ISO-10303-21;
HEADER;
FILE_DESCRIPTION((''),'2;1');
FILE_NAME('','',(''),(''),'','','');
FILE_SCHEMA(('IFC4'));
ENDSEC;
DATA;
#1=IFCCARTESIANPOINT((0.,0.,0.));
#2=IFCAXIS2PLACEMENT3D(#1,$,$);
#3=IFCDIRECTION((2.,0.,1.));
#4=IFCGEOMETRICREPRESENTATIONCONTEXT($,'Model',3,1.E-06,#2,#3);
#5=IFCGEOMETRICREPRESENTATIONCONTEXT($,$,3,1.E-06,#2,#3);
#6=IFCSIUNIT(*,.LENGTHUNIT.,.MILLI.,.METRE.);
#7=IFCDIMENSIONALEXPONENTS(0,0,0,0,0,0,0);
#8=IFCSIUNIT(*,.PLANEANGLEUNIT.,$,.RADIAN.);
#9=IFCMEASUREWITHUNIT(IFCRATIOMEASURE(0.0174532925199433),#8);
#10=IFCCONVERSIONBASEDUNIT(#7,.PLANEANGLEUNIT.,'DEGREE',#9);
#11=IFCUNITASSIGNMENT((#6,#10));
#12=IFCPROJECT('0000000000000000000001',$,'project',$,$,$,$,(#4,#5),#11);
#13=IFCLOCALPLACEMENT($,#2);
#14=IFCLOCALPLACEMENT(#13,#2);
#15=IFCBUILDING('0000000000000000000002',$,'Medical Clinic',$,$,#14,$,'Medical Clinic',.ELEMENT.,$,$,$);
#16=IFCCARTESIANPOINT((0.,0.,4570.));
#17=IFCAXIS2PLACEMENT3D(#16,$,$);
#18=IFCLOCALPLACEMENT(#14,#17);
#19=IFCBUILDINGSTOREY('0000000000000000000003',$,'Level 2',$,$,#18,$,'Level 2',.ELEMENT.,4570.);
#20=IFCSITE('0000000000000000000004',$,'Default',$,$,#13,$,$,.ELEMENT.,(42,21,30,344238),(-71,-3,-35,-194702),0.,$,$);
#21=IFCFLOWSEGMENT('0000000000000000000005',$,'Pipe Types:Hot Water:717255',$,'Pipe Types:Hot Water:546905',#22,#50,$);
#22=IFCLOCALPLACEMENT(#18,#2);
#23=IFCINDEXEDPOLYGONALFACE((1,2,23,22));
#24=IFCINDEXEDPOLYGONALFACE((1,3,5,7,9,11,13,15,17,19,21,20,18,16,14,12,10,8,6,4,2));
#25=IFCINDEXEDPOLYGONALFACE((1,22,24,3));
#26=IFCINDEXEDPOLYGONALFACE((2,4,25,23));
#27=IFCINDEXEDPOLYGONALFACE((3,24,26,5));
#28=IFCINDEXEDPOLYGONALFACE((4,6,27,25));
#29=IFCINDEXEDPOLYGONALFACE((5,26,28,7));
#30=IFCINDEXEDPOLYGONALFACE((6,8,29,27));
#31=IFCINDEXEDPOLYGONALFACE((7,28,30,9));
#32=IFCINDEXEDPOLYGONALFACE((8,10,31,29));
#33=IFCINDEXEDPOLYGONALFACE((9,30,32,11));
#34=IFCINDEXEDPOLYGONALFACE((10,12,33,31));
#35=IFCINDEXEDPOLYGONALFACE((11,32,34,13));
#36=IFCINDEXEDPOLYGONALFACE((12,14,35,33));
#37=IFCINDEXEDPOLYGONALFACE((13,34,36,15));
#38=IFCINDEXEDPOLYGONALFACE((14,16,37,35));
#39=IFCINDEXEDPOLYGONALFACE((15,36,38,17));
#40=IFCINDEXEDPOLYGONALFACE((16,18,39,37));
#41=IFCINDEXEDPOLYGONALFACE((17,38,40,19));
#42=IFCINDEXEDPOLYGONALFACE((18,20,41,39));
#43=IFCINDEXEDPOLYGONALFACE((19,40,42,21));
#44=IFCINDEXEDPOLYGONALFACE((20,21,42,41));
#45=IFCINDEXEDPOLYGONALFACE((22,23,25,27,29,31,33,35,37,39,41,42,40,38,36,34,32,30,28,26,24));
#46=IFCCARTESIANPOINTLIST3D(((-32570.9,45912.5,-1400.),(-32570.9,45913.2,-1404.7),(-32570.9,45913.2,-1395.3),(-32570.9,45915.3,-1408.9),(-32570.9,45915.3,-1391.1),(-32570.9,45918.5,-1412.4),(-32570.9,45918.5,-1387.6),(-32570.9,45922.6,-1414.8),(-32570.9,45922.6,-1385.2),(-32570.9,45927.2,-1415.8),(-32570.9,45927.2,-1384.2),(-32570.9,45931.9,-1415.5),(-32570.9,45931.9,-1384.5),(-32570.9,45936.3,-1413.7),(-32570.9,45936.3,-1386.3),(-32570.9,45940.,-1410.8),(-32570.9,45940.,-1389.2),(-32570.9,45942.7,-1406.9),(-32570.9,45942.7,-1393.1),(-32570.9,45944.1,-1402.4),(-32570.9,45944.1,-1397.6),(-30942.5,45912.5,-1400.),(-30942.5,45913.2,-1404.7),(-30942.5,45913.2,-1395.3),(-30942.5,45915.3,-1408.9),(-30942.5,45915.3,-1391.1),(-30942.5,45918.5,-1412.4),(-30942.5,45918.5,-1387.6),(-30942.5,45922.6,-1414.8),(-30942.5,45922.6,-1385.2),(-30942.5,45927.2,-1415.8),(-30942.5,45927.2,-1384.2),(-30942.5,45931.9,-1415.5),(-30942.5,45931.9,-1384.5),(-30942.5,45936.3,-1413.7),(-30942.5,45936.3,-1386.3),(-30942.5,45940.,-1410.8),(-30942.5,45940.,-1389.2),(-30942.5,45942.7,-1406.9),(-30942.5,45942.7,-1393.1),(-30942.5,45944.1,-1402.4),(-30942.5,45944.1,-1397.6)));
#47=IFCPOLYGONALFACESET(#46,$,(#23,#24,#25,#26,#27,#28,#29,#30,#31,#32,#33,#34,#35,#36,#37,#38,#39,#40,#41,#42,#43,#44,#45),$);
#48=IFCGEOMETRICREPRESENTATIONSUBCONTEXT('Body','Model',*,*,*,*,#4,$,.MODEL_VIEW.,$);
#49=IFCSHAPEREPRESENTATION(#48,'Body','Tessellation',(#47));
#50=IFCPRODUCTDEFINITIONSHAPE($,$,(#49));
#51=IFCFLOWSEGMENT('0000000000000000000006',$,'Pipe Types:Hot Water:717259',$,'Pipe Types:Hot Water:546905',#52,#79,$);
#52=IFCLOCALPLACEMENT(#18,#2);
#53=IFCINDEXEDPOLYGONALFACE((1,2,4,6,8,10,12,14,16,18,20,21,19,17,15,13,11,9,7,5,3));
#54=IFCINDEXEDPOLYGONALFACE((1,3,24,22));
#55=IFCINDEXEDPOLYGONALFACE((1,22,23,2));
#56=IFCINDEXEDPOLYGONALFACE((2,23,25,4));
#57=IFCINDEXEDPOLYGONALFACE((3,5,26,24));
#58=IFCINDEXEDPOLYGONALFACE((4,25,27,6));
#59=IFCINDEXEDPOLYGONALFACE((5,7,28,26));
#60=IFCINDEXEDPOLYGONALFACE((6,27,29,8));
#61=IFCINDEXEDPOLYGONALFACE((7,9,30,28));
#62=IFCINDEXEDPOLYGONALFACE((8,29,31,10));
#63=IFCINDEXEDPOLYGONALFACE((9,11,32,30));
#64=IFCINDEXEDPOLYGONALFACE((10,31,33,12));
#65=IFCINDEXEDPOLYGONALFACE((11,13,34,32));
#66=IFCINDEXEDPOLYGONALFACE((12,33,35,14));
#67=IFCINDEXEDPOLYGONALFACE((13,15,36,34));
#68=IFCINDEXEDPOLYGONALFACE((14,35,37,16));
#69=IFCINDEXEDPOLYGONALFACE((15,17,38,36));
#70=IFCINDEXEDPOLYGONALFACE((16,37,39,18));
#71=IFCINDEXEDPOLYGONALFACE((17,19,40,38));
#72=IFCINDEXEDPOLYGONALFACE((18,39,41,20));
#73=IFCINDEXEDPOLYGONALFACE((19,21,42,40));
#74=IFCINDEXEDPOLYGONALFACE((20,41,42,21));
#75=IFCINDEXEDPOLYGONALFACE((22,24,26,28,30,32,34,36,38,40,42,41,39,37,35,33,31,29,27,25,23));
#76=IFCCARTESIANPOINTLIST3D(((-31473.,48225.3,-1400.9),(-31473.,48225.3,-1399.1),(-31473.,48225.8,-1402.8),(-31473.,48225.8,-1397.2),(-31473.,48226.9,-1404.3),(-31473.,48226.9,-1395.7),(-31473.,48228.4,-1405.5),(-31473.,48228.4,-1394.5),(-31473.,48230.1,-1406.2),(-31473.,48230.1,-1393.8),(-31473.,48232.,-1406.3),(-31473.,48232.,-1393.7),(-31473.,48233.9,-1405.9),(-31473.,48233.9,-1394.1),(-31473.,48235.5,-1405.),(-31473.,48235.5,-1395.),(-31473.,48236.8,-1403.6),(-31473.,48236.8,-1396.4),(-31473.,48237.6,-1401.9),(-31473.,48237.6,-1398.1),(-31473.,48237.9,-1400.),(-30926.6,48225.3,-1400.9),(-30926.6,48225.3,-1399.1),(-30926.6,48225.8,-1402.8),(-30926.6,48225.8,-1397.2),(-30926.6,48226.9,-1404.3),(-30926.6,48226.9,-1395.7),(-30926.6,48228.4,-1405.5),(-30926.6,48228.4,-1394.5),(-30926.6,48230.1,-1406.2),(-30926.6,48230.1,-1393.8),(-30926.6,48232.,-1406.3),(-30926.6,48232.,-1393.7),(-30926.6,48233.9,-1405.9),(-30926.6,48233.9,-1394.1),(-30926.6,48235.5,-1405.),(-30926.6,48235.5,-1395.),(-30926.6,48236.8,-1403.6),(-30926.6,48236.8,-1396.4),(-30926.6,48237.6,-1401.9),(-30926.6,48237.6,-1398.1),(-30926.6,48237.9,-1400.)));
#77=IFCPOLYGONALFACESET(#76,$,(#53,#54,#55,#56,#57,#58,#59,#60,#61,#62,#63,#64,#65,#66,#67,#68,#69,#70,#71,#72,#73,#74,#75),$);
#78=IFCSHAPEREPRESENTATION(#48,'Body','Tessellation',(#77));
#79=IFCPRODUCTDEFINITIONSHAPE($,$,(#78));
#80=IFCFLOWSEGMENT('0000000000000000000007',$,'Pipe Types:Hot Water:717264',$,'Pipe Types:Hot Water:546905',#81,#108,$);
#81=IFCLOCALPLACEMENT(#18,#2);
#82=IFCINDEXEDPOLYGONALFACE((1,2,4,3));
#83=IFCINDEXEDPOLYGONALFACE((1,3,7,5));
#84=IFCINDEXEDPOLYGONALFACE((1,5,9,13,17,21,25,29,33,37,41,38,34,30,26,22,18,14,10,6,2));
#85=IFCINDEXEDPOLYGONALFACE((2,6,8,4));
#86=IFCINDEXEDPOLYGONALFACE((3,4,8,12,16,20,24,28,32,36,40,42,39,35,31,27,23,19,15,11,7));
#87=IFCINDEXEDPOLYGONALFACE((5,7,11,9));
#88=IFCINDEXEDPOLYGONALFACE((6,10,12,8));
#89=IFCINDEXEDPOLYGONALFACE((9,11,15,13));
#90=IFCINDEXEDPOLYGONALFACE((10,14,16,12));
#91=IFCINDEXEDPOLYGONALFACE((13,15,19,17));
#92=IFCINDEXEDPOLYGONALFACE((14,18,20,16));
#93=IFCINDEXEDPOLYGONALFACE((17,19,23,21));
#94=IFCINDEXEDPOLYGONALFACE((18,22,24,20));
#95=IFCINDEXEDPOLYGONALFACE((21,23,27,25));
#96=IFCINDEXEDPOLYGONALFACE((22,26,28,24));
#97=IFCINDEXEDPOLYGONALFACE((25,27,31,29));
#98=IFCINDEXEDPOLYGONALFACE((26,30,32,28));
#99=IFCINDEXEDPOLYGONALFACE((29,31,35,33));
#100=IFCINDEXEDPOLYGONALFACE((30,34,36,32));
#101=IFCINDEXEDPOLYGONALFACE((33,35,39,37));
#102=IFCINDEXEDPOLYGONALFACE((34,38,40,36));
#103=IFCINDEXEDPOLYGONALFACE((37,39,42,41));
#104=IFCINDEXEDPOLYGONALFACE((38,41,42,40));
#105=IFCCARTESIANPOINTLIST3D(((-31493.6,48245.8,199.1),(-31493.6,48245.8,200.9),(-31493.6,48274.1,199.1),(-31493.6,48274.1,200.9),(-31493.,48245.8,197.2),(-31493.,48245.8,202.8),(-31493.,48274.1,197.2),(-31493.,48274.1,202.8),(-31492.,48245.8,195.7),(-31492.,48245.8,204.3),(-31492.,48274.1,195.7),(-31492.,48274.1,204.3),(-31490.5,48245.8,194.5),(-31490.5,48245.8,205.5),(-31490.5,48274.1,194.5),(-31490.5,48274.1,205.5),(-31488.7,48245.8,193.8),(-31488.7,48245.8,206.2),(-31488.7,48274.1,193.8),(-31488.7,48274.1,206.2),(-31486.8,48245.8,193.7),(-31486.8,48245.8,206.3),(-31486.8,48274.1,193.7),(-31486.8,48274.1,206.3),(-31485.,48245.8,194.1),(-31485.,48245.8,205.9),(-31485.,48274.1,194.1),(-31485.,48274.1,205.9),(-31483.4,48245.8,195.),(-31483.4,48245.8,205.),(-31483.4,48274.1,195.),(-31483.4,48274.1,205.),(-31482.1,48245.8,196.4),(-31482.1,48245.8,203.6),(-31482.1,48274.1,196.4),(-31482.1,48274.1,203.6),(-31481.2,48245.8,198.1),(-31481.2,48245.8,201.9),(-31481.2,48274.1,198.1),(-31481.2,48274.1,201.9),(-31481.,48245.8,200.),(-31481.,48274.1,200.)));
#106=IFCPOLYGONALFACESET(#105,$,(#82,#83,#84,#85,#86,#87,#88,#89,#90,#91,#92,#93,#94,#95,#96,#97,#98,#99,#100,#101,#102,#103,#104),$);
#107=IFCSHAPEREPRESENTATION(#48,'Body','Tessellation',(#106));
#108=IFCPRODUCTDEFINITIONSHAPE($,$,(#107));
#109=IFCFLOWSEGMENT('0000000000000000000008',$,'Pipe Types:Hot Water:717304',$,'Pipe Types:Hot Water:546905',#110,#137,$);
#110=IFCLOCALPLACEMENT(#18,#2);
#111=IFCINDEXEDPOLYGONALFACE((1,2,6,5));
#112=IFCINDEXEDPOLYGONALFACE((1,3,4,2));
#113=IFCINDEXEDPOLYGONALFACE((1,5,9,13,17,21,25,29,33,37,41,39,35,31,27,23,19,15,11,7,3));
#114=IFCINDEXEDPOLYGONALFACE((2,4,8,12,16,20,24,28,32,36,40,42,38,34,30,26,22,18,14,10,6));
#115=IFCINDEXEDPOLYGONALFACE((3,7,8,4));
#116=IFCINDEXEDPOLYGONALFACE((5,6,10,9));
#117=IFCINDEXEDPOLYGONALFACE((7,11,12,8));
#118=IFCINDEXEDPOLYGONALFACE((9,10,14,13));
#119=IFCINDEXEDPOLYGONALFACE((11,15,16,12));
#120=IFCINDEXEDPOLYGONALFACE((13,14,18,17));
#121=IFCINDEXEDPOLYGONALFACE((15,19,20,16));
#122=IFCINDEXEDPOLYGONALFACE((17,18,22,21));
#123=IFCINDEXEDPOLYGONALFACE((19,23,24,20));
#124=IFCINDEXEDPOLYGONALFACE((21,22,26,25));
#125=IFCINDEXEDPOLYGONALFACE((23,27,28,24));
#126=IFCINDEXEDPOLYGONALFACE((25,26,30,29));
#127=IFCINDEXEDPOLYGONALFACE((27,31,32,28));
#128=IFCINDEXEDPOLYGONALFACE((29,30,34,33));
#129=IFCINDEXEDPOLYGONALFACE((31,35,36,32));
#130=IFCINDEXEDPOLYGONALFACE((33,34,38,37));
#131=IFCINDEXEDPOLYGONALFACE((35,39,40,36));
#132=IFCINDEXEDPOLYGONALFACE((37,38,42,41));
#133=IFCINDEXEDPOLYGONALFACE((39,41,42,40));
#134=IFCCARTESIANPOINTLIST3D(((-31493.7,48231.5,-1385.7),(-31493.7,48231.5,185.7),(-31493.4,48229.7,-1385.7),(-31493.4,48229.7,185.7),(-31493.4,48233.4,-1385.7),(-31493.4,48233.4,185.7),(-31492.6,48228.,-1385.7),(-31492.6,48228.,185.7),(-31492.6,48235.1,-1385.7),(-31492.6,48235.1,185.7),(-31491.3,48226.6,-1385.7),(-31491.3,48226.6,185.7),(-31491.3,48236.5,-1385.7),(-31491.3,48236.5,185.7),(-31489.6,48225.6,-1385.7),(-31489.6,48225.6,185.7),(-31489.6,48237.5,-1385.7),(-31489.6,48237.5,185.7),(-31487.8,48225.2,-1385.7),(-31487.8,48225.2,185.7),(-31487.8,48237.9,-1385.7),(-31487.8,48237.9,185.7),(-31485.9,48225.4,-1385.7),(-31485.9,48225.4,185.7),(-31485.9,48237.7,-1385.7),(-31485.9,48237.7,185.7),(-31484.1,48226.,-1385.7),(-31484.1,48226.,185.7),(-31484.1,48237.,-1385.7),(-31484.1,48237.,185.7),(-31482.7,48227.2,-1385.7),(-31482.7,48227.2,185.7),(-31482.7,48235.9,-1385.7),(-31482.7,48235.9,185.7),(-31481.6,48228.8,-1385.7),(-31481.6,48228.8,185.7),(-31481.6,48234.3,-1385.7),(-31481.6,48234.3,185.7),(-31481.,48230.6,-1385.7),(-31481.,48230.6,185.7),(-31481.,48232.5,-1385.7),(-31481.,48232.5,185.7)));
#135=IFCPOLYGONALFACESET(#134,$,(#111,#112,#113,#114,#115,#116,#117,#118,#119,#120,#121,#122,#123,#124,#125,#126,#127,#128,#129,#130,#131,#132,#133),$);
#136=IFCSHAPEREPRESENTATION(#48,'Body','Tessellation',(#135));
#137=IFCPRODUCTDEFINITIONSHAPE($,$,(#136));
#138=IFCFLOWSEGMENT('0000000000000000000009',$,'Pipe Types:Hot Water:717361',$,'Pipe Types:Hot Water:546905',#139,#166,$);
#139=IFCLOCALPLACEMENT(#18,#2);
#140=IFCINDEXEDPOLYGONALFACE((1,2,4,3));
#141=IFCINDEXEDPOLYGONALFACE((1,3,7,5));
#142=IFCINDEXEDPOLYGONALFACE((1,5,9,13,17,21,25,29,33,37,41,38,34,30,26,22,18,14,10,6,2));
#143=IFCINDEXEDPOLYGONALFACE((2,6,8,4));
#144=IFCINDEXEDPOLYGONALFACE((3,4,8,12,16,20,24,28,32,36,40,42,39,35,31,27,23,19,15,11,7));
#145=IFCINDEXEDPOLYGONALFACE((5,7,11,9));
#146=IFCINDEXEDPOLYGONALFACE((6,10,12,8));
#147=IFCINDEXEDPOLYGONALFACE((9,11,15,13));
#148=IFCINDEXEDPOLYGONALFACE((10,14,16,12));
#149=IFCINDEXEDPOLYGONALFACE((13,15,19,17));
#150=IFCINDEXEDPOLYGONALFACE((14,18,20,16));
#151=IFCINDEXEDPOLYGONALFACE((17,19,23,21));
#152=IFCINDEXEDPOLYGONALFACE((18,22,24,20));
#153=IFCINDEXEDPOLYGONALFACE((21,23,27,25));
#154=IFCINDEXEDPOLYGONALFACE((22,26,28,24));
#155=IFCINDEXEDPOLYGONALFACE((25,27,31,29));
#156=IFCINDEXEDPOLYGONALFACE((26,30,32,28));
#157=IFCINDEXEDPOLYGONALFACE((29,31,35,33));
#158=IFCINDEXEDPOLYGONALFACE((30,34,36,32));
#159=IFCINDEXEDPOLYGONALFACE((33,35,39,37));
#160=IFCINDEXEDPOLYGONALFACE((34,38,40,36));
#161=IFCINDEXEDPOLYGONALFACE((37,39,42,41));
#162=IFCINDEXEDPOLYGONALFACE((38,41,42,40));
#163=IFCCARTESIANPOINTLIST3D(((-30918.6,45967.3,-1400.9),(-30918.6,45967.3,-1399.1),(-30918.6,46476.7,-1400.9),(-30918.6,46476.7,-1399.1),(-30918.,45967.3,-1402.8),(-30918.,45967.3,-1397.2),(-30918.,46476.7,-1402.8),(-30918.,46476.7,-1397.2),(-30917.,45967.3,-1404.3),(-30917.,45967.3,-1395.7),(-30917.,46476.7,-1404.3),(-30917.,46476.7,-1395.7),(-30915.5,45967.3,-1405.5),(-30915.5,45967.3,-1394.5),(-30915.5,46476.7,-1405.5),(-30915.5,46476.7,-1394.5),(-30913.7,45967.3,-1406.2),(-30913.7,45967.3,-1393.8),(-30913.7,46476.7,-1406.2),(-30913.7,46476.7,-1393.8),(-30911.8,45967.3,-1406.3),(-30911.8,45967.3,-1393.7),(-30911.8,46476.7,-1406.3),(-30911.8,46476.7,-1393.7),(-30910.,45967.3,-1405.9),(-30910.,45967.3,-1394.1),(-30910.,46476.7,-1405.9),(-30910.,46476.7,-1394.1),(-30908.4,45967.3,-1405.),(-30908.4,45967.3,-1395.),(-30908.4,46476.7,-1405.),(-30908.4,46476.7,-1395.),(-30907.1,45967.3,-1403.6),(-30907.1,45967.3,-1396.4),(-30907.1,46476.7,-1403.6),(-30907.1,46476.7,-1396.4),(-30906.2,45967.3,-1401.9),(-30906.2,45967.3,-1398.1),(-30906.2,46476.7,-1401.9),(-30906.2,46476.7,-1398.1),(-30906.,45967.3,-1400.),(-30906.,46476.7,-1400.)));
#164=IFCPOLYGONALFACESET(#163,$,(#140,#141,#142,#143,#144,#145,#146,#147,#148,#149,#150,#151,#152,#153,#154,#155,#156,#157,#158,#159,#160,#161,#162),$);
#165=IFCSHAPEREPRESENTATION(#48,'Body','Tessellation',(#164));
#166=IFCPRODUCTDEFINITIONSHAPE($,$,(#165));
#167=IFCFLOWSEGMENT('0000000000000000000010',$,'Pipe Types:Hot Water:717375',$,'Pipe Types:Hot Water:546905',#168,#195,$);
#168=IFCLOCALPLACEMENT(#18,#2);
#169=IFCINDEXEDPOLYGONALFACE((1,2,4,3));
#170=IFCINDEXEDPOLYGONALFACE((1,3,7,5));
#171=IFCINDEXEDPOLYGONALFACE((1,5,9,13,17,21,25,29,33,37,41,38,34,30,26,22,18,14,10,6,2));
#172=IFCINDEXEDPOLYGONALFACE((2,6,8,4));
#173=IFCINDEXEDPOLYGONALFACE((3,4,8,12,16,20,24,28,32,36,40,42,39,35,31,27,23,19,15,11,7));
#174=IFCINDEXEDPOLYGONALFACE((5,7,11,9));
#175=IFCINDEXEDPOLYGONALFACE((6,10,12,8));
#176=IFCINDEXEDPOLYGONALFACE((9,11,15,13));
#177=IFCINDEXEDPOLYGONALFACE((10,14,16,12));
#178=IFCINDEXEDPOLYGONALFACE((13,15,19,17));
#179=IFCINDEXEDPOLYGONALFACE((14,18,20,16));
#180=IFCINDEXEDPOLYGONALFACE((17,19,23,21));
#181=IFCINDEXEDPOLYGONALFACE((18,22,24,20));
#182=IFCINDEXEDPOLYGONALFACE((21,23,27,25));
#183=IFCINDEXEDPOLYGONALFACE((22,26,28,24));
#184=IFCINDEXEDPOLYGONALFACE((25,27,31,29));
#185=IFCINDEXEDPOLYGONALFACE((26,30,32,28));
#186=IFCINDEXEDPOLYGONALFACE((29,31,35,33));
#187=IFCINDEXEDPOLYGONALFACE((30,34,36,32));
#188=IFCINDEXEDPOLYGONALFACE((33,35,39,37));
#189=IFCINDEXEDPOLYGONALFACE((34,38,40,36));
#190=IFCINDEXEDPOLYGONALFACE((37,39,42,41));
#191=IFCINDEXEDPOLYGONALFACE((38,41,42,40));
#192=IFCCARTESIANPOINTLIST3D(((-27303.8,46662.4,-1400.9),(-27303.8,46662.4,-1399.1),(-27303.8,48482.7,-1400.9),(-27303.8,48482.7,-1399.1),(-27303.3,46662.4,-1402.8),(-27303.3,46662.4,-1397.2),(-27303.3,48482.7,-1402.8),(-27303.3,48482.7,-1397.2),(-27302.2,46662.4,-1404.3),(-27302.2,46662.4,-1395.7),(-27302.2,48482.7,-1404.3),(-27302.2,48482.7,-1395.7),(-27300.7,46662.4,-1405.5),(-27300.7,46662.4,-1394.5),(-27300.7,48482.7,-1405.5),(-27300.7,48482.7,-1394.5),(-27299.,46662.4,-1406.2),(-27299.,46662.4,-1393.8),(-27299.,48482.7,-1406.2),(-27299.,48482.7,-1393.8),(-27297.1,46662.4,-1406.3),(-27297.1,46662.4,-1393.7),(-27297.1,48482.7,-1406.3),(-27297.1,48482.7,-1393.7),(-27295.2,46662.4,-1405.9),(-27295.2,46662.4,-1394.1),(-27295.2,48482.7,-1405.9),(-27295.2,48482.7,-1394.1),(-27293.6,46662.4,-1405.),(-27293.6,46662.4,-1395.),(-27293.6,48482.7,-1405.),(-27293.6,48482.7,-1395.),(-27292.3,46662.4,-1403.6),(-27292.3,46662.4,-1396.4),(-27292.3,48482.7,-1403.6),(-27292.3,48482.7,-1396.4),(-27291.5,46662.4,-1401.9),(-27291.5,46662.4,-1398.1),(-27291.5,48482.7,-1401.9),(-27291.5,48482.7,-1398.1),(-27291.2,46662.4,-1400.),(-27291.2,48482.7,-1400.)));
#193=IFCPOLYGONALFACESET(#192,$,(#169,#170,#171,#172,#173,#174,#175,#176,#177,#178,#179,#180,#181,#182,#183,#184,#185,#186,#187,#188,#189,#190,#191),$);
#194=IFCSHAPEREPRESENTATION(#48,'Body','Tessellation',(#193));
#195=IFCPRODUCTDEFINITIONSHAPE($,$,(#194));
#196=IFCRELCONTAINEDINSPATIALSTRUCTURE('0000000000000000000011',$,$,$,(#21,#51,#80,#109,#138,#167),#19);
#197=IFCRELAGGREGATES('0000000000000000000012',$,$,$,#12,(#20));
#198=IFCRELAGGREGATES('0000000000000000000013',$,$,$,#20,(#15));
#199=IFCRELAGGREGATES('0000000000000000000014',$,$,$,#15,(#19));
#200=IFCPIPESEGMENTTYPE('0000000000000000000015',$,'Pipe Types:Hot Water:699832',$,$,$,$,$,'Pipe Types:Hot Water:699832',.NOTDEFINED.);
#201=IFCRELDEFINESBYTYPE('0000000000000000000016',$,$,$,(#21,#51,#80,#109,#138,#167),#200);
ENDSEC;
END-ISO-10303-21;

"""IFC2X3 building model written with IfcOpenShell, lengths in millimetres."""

from ifc_helpers import new_model, entity, si_unit, converted_unit, direction, frame, frame_2d, origin, origin_2d_with_axis, place, context, subcontext, project, spatial, circle, extrude, type_object, element, save


model = new_model("IFC2X3")

# Units and contexts
model_context = context("Model", 3, precision=1e-06, world=origin(), true_north=direction((2.0, 0.0, 1.0)))
context_of_model = context(None, 3, precision=1e-06, world=origin(), true_north=direction((2.0, 0.0, 1.0)))
body_context = subcontext(model_context, "Body", "Model", "MODEL_VIEW")
ifc_project = project(units=[si_unit("LENGTHUNIT", "METRE", prefix="MILLI"), converted_unit("PLANEANGLEUNIT", "DEGREE", entity("IfcRatioMeasure", 0.0174532925199433), si_unit("PLANEANGLEUNIT", "RADIAN"), dimensions=[0, 0, 0, 0, 0, 0, 0])], contexts=[model_context, context_of_model])

# Site, building, storey
site_placement = place(None, origin())
site = spatial("IfcSite", under=ifc_project, at=site_placement, Name="Default", CompositionType="ELEMENT", RefLatitude=(42, 21, 30, 344238), RefLongitude=(-71, -3, -35, -194702), RefElevation=0.0)
building_placement = place(site_placement, origin())
building = spatial("IfcBuilding", under=site, at=building_placement, Name="Medical Clinic", LongName="Medical Clinic", CompositionType="ELEMENT")
storey_placement = place(building_placement, frame((0.0, 0.0, 4570.0)))
storey = spatial("IfcBuildingStorey", under=building, at=storey_placement, Name="Level 2", LongName="Level 2", CompositionType="ELEMENT", Elevation=4570.0)

# Flow segments
pipe_segment_type = type_object("IfcPipeSegmentType", Name="Pipe Types:Hot Water:699832", ElementType="Pipe Types:Hot Water:699832", PredefinedType="NOTDEFINED")
flow_segment_1_placement = place(storey_placement, origin())
element("IfcFlowSegment", 1, at=flow_segment_1_placement, inside=storey, type_object=pipe_segment_type, Name="Pipe Types:Hot Water:717255", ObjectType="Pipe Types:Hot Water:546905", context=body_context, shape_type="SweptSolid", body=[
    extrude(circle(Radius=15.9, at=origin_2d_with_axis()), frame((-32570.9, 45928.4, -1400.0), z_axis=(1.0, 0.0, 0.0), x_axis=(0.0, -1.0, 0.0)), (0.0, 0.0, 1.0), 1628.4),
])
flow_segment_2_placement = place(storey_placement, origin())
element("IfcFlowSegment", 2, at=flow_segment_2_placement, inside=storey, type_object=pipe_segment_type, Name="Pipe Types:Hot Water:717259", ObjectType="Pipe Types:Hot Water:546905", context=body_context, shape_type="SweptSolid", body=[
    extrude(circle(Radius=6.3, at=frame_2d((0.0, 0.0), x_axis=(1.0, 0.0))), frame((-31473.0, 48231.5, -1400.0), z_axis=(1.0, 0.0, 0.0), x_axis=(0.0, 1.0, 0.0)), (0.0, 0.0, 1.0), 546.4),
])
flow_segment_3_placement = place(storey_placement, origin())
element("IfcFlowSegment", 3, at=flow_segment_3_placement, inside=storey, type_object=pipe_segment_type, Name="Pipe Types:Hot Water:717264", ObjectType="Pipe Types:Hot Water:546905", context=body_context, shape_type="SweptSolid", body=[
    extrude(circle(Radius=6.3, at=origin_2d_with_axis()), frame((-31487.3, 48245.8, 200.0), z_axis=(0.0, 1.0, 0.0), x_axis=(1.0, 0.0, 0.0)), (0.0, 0.0, 1.0), 28.3),
])
flow_segment_4_placement = place(storey_placement, origin())
element("IfcFlowSegment", 4, at=flow_segment_4_placement, inside=storey, type_object=pipe_segment_type, Name="Pipe Types:Hot Water:717304", ObjectType="Pipe Types:Hot Water:546905", context=body_context, shape_type="SweptSolid", body=[
    extrude(circle(Radius=6.3, at=origin_2d_with_axis()), frame((-31487.3, 48231.5, -1385.7), z_axis=(0.0, 0.0, 1.0), x_axis=(-1.0, 0.0, 0.0)), (0.0, 0.0, 1.0), 1571.4),
])
flow_segment_5_placement = place(storey_placement, origin())
element("IfcFlowSegment", 5, at=flow_segment_5_placement, inside=storey, type_object=pipe_segment_type, Name="Pipe Types:Hot Water:717361", ObjectType="Pipe Types:Hot Water:546905", context=body_context, shape_type="SweptSolid", body=[
    extrude(circle(Radius=6.3, at=origin_2d_with_axis()), frame((-30912.3, 45967.3, -1400.0), z_axis=(0.0, 1.0, 0.0), x_axis=(1.0, 0.0, 0.0)), (0.0, 0.0, 1.0), 509.4),
])
flow_segment_6_placement = place(storey_placement, origin())
element("IfcFlowSegment", 6, at=flow_segment_6_placement, inside=storey, type_object=pipe_segment_type, Name="Pipe Types:Hot Water:717375", ObjectType="Pipe Types:Hot Water:546905", context=body_context, shape_type="SweptSolid", body=[
    extrude(circle(Radius=6.3, at=origin_2d_with_axis()), frame((-27297.6, 46662.4, -1400.0), z_axis=(0.0, 1.0, 0.0), x_axis=(1.0, 0.0, 0.0)), (0.0, 0.0, 1.0), 1820.3),
])

save(model, "model.ifc")
